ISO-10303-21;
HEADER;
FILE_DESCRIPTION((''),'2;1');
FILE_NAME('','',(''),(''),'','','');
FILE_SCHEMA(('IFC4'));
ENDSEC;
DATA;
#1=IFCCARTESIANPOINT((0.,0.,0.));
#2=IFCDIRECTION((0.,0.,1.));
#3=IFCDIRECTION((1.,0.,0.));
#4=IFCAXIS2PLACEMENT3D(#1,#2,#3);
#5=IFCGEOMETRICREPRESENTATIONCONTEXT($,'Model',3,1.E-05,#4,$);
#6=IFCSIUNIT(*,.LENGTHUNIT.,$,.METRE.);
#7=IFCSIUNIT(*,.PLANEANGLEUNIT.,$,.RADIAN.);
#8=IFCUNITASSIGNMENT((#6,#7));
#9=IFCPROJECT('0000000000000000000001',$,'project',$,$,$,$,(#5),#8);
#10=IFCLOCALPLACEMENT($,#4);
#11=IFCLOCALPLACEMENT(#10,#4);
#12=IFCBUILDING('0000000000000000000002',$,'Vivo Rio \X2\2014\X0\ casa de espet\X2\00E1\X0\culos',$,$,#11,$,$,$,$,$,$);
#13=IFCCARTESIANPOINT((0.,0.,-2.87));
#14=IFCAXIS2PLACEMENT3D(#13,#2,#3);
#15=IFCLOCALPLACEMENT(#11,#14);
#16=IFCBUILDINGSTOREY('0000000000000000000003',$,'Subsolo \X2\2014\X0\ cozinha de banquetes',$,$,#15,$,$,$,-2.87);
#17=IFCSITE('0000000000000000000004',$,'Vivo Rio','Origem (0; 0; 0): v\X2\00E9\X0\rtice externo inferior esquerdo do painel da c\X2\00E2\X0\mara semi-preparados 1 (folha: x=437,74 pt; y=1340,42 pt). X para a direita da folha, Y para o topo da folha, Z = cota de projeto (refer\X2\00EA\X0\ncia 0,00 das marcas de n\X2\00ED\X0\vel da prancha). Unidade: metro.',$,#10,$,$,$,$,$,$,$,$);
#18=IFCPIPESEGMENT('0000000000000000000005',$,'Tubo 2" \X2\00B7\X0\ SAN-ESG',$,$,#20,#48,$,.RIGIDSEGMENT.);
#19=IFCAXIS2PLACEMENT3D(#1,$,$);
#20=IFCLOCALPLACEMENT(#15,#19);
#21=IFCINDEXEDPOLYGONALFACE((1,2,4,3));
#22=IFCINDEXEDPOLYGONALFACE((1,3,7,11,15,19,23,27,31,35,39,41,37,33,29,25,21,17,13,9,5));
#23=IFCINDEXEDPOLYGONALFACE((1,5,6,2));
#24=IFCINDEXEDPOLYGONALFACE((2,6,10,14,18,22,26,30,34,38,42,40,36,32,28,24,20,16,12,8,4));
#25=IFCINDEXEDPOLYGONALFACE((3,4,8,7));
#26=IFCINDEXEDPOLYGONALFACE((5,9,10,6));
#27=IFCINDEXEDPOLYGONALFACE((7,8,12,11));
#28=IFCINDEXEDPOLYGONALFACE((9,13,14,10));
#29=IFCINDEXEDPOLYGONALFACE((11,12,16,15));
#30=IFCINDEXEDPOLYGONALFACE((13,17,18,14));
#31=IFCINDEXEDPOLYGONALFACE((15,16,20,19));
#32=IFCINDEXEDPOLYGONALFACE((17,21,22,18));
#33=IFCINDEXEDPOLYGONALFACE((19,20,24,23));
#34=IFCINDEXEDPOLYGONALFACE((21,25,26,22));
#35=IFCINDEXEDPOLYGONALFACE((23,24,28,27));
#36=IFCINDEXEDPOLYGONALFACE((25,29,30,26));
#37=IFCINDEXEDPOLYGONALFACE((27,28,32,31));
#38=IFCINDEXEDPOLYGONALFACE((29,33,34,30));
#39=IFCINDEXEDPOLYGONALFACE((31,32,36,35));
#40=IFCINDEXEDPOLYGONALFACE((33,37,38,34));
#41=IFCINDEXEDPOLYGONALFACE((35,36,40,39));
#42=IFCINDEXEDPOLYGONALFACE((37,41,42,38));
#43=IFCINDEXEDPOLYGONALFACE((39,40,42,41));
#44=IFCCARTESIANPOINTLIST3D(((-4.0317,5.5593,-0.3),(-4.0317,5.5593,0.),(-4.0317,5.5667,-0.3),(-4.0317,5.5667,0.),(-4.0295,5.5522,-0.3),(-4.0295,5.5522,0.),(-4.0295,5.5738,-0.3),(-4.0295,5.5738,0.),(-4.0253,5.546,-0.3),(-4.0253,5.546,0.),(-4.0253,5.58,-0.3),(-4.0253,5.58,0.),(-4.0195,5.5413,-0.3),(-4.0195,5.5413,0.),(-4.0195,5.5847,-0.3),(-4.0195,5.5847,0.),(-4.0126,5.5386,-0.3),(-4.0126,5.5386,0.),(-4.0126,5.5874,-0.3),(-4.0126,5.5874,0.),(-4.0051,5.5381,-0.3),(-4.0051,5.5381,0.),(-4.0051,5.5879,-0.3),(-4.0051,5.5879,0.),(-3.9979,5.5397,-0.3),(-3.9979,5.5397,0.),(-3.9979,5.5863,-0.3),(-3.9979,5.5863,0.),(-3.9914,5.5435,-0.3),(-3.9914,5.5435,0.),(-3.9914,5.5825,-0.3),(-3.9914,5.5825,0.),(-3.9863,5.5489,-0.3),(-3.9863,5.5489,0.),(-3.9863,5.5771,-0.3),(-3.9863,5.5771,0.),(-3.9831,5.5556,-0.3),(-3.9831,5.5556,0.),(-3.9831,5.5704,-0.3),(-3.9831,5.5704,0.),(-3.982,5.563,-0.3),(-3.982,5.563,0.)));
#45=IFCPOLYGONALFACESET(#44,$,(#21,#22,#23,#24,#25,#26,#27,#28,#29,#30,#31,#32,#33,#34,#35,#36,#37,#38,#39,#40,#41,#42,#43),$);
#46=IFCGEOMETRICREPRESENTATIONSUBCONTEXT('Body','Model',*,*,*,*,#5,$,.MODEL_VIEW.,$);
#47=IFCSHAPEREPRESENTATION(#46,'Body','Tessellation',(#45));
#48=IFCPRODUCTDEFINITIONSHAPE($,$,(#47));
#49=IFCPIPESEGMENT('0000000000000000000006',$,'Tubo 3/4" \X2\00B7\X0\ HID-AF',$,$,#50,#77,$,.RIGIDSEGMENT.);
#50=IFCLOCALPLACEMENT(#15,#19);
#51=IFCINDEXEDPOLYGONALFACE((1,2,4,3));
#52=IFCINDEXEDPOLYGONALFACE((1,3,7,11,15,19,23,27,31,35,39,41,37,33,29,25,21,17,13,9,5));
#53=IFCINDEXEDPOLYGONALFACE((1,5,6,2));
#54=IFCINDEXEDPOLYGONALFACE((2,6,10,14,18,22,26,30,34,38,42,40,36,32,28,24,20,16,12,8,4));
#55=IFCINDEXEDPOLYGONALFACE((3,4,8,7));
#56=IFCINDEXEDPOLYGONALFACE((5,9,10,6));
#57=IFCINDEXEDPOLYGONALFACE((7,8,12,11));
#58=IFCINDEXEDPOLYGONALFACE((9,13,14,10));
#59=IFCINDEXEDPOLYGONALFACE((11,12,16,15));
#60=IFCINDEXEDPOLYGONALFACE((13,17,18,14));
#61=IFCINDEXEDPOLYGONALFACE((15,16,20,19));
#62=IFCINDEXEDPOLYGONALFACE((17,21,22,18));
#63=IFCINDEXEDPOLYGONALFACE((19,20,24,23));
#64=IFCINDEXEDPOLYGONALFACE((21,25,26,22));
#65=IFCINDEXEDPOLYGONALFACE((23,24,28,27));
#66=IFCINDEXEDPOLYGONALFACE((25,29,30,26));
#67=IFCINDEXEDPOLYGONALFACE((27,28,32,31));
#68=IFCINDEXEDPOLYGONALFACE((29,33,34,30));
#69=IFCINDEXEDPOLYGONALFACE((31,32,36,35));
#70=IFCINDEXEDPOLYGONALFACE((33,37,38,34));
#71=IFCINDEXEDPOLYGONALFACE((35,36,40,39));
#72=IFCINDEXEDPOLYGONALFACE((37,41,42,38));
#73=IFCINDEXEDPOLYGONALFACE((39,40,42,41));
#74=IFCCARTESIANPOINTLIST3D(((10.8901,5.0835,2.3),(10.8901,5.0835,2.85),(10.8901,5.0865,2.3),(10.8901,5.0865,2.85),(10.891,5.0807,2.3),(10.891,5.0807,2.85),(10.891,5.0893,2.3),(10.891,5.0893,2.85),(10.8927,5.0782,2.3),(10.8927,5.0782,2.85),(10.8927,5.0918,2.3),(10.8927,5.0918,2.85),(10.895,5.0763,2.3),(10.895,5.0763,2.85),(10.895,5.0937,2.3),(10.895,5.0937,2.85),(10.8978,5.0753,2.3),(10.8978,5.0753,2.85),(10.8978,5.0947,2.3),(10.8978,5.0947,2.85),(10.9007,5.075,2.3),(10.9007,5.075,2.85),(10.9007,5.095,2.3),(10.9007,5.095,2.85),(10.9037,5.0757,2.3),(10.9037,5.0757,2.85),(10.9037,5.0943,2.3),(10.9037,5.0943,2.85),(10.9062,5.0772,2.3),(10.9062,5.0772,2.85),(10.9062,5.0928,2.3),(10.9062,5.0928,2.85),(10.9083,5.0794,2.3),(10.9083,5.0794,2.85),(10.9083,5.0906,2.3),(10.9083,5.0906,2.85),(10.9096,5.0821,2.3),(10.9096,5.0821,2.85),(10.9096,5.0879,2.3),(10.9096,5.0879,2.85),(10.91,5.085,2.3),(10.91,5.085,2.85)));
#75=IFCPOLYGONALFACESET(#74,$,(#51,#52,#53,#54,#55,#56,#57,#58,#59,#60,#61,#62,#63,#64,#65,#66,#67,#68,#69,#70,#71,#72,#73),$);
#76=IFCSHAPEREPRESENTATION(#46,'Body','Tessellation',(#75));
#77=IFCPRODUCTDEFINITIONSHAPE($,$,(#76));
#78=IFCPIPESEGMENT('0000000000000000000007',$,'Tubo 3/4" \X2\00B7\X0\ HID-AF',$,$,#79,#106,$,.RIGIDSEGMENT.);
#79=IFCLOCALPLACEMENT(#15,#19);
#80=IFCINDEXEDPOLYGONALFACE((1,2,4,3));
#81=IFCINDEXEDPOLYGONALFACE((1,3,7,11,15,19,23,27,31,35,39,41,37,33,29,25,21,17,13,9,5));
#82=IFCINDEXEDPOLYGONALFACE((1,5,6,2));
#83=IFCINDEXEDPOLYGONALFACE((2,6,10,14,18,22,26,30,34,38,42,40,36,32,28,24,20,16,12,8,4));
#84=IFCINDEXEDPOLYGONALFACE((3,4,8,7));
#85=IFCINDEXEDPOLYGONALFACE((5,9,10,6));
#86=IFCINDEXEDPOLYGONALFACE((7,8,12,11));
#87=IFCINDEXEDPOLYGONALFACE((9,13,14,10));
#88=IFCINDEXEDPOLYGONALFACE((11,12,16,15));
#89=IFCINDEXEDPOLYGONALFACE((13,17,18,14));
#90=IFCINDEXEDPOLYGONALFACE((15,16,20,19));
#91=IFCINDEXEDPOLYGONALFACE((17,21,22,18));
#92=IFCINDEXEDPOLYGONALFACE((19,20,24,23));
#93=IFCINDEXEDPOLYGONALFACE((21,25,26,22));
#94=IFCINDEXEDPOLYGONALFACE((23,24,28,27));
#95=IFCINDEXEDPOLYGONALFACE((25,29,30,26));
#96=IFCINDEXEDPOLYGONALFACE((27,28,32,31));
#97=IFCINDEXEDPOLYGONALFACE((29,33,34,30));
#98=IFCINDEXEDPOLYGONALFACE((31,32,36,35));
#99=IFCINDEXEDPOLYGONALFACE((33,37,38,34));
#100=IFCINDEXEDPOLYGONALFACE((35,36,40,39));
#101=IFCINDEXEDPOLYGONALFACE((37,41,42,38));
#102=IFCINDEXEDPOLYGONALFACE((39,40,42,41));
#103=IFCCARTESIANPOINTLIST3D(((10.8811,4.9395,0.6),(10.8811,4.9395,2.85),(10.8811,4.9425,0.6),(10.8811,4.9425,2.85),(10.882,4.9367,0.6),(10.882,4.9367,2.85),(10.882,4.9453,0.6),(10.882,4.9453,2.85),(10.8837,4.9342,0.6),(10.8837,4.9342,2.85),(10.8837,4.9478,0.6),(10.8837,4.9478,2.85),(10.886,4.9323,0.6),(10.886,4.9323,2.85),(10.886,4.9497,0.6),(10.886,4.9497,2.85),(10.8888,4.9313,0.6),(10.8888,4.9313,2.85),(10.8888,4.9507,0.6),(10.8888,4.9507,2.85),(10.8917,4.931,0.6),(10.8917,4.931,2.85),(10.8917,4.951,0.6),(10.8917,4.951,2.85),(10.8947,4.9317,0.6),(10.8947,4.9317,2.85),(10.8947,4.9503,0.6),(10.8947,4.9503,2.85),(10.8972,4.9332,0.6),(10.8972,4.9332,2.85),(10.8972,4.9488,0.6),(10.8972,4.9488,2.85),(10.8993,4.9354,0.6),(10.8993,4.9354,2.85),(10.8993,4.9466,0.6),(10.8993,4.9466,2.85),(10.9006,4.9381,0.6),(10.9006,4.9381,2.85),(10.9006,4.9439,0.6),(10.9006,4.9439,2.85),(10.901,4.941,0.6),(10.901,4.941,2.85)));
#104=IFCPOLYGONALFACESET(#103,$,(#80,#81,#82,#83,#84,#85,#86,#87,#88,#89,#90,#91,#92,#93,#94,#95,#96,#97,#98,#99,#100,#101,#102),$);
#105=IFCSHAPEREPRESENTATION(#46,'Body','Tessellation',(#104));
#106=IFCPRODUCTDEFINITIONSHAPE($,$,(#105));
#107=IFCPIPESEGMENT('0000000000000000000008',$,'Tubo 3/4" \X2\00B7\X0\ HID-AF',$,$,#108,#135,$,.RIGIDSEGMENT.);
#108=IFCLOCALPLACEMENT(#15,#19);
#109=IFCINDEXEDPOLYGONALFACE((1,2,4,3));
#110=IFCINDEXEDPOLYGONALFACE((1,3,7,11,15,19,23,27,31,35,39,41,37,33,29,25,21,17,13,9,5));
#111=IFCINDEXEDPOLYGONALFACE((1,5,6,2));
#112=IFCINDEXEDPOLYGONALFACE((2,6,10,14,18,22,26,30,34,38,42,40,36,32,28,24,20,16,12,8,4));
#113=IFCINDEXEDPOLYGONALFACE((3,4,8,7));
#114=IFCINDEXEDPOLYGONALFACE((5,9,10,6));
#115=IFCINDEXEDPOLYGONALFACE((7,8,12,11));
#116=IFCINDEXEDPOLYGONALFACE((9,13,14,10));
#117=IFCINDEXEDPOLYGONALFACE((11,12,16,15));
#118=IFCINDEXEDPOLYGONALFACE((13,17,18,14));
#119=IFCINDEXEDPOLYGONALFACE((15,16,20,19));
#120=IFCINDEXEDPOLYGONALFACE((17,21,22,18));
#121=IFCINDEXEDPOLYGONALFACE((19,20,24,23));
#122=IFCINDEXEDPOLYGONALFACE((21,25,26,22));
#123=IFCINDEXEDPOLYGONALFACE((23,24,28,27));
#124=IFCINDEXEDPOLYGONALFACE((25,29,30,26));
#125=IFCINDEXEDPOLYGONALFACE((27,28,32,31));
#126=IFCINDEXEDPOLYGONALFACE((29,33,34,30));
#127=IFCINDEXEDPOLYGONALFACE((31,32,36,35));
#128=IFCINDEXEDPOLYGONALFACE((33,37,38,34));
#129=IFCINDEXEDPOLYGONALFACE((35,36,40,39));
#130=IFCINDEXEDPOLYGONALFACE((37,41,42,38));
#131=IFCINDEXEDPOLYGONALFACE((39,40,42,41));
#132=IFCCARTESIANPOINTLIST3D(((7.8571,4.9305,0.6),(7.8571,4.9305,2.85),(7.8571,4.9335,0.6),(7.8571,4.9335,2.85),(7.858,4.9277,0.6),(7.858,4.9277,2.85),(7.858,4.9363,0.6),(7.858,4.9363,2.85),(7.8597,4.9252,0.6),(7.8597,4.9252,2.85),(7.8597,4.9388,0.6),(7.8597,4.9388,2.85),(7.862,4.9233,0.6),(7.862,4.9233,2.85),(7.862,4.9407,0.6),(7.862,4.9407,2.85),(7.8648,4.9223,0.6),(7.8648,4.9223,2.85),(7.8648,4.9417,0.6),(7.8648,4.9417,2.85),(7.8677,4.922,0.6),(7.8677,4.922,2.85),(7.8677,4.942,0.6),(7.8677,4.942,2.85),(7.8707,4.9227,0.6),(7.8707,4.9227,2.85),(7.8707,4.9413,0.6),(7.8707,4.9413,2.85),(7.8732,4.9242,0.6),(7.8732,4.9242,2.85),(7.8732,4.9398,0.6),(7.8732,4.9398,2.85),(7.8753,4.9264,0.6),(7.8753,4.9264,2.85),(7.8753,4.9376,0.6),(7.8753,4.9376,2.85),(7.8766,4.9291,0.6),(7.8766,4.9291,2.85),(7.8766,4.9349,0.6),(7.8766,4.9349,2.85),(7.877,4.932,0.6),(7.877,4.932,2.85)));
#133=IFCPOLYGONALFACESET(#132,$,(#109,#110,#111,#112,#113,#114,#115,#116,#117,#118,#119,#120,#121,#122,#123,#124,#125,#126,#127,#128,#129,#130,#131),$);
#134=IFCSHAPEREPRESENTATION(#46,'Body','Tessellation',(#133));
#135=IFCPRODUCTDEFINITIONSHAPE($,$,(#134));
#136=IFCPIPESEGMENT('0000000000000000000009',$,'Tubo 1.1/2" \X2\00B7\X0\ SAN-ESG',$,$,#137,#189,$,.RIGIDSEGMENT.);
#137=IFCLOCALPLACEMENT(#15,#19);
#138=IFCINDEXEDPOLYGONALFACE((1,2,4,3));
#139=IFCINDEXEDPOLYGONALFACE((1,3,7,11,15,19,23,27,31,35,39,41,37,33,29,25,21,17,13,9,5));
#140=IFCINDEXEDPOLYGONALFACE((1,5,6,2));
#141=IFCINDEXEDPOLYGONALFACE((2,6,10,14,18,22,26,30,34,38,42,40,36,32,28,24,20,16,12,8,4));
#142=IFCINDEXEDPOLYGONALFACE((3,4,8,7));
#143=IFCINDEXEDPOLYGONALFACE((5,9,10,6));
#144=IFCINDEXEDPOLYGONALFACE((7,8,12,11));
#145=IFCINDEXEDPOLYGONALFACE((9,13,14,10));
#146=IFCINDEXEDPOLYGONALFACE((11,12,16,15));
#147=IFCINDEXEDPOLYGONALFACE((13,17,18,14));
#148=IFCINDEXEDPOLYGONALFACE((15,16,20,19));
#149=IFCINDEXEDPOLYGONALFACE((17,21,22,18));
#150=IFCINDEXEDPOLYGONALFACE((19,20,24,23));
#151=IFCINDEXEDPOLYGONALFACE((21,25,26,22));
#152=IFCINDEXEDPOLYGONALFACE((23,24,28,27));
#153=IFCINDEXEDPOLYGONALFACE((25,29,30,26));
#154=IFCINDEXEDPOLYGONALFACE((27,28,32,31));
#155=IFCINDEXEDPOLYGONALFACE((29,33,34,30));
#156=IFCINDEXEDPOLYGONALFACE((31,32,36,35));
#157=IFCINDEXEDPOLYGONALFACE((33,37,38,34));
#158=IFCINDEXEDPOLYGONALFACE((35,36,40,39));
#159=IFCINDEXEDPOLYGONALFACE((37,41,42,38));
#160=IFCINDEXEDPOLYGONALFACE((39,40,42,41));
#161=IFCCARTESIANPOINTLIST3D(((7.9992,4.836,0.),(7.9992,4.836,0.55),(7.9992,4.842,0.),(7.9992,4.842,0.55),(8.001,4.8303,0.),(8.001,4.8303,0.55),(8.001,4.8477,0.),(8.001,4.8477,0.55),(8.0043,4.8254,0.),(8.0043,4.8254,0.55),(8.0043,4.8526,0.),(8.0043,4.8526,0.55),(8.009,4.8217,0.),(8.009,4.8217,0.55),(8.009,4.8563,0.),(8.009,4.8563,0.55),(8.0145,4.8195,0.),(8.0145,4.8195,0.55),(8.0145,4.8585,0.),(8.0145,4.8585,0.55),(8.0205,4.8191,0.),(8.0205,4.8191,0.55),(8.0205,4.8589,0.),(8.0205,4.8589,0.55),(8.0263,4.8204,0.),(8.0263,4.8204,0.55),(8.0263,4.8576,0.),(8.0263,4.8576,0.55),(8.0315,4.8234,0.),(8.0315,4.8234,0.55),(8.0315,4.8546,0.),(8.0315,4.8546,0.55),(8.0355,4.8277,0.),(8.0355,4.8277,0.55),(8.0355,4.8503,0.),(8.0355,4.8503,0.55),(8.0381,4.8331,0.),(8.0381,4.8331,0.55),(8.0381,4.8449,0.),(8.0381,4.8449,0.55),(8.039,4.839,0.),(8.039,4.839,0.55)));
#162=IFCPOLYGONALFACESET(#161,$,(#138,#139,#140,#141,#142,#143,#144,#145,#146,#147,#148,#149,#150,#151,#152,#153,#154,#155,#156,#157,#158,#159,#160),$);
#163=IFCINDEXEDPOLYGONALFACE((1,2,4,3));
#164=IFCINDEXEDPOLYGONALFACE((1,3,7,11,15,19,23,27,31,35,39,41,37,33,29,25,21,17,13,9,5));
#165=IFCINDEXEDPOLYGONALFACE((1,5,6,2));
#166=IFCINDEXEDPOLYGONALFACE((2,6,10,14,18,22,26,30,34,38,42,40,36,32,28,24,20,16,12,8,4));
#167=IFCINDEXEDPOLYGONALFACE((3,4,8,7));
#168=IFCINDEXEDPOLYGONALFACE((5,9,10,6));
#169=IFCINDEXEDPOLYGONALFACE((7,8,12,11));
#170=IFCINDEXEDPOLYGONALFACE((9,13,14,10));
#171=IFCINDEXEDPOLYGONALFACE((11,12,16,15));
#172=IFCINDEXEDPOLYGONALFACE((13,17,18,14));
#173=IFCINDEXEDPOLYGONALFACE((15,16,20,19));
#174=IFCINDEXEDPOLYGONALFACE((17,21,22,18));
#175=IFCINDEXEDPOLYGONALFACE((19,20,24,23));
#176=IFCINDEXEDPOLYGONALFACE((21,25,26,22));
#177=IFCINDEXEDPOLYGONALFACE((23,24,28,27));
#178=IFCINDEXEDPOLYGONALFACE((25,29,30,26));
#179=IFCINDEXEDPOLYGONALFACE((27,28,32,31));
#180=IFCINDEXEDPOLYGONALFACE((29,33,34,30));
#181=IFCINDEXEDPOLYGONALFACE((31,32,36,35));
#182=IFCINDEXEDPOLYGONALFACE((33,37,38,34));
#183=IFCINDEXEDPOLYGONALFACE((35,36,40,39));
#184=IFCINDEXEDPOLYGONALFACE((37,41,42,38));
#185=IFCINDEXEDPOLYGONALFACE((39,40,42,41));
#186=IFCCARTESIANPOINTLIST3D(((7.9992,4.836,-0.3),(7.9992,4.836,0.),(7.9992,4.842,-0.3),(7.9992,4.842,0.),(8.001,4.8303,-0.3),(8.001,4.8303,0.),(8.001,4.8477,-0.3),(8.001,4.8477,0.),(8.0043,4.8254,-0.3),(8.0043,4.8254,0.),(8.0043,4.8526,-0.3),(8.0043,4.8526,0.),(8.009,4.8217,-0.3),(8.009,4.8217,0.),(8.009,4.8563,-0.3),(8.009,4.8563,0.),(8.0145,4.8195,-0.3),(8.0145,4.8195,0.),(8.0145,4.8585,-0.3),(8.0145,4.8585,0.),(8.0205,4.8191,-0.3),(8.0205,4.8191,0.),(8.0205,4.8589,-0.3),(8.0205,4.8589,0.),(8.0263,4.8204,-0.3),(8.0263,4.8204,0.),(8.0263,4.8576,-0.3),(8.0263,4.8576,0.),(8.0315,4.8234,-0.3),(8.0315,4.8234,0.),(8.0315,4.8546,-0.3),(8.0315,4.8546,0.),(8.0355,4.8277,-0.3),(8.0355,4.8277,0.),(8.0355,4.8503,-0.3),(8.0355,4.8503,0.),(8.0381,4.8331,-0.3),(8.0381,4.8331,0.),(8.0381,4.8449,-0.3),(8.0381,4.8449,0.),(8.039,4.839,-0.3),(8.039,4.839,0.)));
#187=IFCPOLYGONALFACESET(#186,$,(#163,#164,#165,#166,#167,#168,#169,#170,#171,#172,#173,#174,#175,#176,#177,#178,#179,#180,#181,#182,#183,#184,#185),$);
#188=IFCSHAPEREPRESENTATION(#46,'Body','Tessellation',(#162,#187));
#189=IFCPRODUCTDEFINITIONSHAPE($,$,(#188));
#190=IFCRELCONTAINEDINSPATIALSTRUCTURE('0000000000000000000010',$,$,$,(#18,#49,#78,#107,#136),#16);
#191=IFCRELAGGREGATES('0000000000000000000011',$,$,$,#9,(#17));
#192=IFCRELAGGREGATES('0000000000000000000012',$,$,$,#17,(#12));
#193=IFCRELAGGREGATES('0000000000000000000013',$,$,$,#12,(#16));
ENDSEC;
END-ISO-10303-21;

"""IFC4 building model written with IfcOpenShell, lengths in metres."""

from ifc_helpers import new_model, si_unit, frame, origin_with_axes, origin_2d, place, context, subcontext, project, spatial, circle, extrude, element, save


model = new_model("IFC4")

# Units and contexts
model_context = context("Model", 3, precision=1e-05, world=origin_with_axes())
body_context = subcontext(model_context, "Body", "Model", "MODEL_VIEW")
ifc_project = project(units=[si_unit("LENGTHUNIT", "METRE"), si_unit("PLANEANGLEUNIT", "RADIAN")], contexts=[model_context])

# Site, building, storey
site_placement = place(None, origin_with_axes())
site = spatial("IfcSite", under=ifc_project, at=site_placement, Name="Vivo Rio", Description="Origem (0; 0; 0): vértice externo inferior esquerdo do painel da câmara semi-preparados 1 (folha: x=437,74 pt; y=1340,42 pt). X para a direita da folha, Y para o topo da folha, Z = cota de projeto (referência 0,00 das marcas de nível da prancha). Unidade: metro.")
building_placement = place(site_placement, origin_with_axes())
building = spatial("IfcBuilding", under=site, at=building_placement, Name="Vivo Rio — casa de espetáculos")
storey_placement = place(building_placement, frame((0.0, 0.0, -2.87), z_axis=(0.0, 0.0, 1.0), x_axis=(1.0, 0.0, 0.0)))
storey = spatial("IfcBuildingStorey", under=building, at=storey_placement, Name="Subsolo — cozinha de banquetes", Elevation=-2.87)

# Pipe segments
pipe_segment_1_placement = place(storey_placement, origin_with_axes())
element("IfcPipeSegment", 1, at=pipe_segment_1_placement, inside=storey, Name="Tubo 2\" · SAN-ESG", PredefinedType="RIGIDSEGMENT", context=body_context, shape_type="SweptSolid", body=[
    extrude(circle(Radius=0.025, at=origin_2d()), frame((-4.007, 5.563, 0.0), z_axis=(0.0, 0.0, -1.0), x_axis=(1.0, 0.0, 0.0)), (0.0, 0.0, 1.0), 0.3),
])
pipe_segment_2_placement = place(storey_placement, origin_with_axes())
element("IfcPipeSegment", 2, at=pipe_segment_2_placement, inside=storey, Name="Tubo 3/4\" · HID-AF", PredefinedType="RIGIDSEGMENT", context=body_context, shape_type="SweptSolid", body=[
    extrude(circle(Radius=0.01, at=origin_2d()), frame((10.9, 5.085, 2.85), z_axis=(0.0, 0.0, -1.0), x_axis=(1.0, 0.0, 0.0)), (0.0, 0.0, 1.0), 0.55),
])
pipe_segment_3_placement = place(storey_placement, origin_with_axes())
element("IfcPipeSegment", 3, at=pipe_segment_3_placement, inside=storey, Name="Tubo 3/4\" · HID-AF", PredefinedType="RIGIDSEGMENT", context=body_context, shape_type="SweptSolid", body=[
    extrude(circle(Radius=0.01, at=origin_2d()), frame((10.891, 4.941, 2.85), z_axis=(0.0, 0.0, -1.0), x_axis=(1.0, 0.0, 0.0)), (0.0, 0.0, 1.0), 2.25),
])
pipe_segment_4_placement = place(storey_placement, origin_with_axes())
element("IfcPipeSegment", 4, at=pipe_segment_4_placement, inside=storey, Name="Tubo 3/4\" · HID-AF", PredefinedType="RIGIDSEGMENT", context=body_context, shape_type="SweptSolid", body=[
    extrude(circle(Radius=0.01, at=origin_2d()), frame((7.867, 4.932, 2.85), z_axis=(0.0, 0.0, -1.0), x_axis=(1.0, 0.0, 0.0)), (0.0, 0.0, 1.0), 2.25),
])
pipe_segment_5_placement = place(storey_placement, origin_with_axes())
element("IfcPipeSegment", 5, at=pipe_segment_5_placement, inside=storey, Name="Tubo 1.1/2\" · SAN-ESG", PredefinedType="RIGIDSEGMENT", context=body_context, shape_type="SweptSolid", body=[
    extrude(circle(Radius=0.02, at=origin_2d()), frame((8.019, 4.839, 0.55), z_axis=(0.0, 0.0, -1.0), x_axis=(1.0, 0.0, 0.0)), (0.0, 0.0, 1.0), 0.55),
    extrude(circle(Radius=0.02, at=origin_2d()), frame((8.019, 4.839, 0.0), z_axis=(0.0, 0.0, -1.0), x_axis=(1.0, 0.0, 0.0)), (0.0, 0.0, 1.0), 0.3),
])

save(model, "model.ifc")
